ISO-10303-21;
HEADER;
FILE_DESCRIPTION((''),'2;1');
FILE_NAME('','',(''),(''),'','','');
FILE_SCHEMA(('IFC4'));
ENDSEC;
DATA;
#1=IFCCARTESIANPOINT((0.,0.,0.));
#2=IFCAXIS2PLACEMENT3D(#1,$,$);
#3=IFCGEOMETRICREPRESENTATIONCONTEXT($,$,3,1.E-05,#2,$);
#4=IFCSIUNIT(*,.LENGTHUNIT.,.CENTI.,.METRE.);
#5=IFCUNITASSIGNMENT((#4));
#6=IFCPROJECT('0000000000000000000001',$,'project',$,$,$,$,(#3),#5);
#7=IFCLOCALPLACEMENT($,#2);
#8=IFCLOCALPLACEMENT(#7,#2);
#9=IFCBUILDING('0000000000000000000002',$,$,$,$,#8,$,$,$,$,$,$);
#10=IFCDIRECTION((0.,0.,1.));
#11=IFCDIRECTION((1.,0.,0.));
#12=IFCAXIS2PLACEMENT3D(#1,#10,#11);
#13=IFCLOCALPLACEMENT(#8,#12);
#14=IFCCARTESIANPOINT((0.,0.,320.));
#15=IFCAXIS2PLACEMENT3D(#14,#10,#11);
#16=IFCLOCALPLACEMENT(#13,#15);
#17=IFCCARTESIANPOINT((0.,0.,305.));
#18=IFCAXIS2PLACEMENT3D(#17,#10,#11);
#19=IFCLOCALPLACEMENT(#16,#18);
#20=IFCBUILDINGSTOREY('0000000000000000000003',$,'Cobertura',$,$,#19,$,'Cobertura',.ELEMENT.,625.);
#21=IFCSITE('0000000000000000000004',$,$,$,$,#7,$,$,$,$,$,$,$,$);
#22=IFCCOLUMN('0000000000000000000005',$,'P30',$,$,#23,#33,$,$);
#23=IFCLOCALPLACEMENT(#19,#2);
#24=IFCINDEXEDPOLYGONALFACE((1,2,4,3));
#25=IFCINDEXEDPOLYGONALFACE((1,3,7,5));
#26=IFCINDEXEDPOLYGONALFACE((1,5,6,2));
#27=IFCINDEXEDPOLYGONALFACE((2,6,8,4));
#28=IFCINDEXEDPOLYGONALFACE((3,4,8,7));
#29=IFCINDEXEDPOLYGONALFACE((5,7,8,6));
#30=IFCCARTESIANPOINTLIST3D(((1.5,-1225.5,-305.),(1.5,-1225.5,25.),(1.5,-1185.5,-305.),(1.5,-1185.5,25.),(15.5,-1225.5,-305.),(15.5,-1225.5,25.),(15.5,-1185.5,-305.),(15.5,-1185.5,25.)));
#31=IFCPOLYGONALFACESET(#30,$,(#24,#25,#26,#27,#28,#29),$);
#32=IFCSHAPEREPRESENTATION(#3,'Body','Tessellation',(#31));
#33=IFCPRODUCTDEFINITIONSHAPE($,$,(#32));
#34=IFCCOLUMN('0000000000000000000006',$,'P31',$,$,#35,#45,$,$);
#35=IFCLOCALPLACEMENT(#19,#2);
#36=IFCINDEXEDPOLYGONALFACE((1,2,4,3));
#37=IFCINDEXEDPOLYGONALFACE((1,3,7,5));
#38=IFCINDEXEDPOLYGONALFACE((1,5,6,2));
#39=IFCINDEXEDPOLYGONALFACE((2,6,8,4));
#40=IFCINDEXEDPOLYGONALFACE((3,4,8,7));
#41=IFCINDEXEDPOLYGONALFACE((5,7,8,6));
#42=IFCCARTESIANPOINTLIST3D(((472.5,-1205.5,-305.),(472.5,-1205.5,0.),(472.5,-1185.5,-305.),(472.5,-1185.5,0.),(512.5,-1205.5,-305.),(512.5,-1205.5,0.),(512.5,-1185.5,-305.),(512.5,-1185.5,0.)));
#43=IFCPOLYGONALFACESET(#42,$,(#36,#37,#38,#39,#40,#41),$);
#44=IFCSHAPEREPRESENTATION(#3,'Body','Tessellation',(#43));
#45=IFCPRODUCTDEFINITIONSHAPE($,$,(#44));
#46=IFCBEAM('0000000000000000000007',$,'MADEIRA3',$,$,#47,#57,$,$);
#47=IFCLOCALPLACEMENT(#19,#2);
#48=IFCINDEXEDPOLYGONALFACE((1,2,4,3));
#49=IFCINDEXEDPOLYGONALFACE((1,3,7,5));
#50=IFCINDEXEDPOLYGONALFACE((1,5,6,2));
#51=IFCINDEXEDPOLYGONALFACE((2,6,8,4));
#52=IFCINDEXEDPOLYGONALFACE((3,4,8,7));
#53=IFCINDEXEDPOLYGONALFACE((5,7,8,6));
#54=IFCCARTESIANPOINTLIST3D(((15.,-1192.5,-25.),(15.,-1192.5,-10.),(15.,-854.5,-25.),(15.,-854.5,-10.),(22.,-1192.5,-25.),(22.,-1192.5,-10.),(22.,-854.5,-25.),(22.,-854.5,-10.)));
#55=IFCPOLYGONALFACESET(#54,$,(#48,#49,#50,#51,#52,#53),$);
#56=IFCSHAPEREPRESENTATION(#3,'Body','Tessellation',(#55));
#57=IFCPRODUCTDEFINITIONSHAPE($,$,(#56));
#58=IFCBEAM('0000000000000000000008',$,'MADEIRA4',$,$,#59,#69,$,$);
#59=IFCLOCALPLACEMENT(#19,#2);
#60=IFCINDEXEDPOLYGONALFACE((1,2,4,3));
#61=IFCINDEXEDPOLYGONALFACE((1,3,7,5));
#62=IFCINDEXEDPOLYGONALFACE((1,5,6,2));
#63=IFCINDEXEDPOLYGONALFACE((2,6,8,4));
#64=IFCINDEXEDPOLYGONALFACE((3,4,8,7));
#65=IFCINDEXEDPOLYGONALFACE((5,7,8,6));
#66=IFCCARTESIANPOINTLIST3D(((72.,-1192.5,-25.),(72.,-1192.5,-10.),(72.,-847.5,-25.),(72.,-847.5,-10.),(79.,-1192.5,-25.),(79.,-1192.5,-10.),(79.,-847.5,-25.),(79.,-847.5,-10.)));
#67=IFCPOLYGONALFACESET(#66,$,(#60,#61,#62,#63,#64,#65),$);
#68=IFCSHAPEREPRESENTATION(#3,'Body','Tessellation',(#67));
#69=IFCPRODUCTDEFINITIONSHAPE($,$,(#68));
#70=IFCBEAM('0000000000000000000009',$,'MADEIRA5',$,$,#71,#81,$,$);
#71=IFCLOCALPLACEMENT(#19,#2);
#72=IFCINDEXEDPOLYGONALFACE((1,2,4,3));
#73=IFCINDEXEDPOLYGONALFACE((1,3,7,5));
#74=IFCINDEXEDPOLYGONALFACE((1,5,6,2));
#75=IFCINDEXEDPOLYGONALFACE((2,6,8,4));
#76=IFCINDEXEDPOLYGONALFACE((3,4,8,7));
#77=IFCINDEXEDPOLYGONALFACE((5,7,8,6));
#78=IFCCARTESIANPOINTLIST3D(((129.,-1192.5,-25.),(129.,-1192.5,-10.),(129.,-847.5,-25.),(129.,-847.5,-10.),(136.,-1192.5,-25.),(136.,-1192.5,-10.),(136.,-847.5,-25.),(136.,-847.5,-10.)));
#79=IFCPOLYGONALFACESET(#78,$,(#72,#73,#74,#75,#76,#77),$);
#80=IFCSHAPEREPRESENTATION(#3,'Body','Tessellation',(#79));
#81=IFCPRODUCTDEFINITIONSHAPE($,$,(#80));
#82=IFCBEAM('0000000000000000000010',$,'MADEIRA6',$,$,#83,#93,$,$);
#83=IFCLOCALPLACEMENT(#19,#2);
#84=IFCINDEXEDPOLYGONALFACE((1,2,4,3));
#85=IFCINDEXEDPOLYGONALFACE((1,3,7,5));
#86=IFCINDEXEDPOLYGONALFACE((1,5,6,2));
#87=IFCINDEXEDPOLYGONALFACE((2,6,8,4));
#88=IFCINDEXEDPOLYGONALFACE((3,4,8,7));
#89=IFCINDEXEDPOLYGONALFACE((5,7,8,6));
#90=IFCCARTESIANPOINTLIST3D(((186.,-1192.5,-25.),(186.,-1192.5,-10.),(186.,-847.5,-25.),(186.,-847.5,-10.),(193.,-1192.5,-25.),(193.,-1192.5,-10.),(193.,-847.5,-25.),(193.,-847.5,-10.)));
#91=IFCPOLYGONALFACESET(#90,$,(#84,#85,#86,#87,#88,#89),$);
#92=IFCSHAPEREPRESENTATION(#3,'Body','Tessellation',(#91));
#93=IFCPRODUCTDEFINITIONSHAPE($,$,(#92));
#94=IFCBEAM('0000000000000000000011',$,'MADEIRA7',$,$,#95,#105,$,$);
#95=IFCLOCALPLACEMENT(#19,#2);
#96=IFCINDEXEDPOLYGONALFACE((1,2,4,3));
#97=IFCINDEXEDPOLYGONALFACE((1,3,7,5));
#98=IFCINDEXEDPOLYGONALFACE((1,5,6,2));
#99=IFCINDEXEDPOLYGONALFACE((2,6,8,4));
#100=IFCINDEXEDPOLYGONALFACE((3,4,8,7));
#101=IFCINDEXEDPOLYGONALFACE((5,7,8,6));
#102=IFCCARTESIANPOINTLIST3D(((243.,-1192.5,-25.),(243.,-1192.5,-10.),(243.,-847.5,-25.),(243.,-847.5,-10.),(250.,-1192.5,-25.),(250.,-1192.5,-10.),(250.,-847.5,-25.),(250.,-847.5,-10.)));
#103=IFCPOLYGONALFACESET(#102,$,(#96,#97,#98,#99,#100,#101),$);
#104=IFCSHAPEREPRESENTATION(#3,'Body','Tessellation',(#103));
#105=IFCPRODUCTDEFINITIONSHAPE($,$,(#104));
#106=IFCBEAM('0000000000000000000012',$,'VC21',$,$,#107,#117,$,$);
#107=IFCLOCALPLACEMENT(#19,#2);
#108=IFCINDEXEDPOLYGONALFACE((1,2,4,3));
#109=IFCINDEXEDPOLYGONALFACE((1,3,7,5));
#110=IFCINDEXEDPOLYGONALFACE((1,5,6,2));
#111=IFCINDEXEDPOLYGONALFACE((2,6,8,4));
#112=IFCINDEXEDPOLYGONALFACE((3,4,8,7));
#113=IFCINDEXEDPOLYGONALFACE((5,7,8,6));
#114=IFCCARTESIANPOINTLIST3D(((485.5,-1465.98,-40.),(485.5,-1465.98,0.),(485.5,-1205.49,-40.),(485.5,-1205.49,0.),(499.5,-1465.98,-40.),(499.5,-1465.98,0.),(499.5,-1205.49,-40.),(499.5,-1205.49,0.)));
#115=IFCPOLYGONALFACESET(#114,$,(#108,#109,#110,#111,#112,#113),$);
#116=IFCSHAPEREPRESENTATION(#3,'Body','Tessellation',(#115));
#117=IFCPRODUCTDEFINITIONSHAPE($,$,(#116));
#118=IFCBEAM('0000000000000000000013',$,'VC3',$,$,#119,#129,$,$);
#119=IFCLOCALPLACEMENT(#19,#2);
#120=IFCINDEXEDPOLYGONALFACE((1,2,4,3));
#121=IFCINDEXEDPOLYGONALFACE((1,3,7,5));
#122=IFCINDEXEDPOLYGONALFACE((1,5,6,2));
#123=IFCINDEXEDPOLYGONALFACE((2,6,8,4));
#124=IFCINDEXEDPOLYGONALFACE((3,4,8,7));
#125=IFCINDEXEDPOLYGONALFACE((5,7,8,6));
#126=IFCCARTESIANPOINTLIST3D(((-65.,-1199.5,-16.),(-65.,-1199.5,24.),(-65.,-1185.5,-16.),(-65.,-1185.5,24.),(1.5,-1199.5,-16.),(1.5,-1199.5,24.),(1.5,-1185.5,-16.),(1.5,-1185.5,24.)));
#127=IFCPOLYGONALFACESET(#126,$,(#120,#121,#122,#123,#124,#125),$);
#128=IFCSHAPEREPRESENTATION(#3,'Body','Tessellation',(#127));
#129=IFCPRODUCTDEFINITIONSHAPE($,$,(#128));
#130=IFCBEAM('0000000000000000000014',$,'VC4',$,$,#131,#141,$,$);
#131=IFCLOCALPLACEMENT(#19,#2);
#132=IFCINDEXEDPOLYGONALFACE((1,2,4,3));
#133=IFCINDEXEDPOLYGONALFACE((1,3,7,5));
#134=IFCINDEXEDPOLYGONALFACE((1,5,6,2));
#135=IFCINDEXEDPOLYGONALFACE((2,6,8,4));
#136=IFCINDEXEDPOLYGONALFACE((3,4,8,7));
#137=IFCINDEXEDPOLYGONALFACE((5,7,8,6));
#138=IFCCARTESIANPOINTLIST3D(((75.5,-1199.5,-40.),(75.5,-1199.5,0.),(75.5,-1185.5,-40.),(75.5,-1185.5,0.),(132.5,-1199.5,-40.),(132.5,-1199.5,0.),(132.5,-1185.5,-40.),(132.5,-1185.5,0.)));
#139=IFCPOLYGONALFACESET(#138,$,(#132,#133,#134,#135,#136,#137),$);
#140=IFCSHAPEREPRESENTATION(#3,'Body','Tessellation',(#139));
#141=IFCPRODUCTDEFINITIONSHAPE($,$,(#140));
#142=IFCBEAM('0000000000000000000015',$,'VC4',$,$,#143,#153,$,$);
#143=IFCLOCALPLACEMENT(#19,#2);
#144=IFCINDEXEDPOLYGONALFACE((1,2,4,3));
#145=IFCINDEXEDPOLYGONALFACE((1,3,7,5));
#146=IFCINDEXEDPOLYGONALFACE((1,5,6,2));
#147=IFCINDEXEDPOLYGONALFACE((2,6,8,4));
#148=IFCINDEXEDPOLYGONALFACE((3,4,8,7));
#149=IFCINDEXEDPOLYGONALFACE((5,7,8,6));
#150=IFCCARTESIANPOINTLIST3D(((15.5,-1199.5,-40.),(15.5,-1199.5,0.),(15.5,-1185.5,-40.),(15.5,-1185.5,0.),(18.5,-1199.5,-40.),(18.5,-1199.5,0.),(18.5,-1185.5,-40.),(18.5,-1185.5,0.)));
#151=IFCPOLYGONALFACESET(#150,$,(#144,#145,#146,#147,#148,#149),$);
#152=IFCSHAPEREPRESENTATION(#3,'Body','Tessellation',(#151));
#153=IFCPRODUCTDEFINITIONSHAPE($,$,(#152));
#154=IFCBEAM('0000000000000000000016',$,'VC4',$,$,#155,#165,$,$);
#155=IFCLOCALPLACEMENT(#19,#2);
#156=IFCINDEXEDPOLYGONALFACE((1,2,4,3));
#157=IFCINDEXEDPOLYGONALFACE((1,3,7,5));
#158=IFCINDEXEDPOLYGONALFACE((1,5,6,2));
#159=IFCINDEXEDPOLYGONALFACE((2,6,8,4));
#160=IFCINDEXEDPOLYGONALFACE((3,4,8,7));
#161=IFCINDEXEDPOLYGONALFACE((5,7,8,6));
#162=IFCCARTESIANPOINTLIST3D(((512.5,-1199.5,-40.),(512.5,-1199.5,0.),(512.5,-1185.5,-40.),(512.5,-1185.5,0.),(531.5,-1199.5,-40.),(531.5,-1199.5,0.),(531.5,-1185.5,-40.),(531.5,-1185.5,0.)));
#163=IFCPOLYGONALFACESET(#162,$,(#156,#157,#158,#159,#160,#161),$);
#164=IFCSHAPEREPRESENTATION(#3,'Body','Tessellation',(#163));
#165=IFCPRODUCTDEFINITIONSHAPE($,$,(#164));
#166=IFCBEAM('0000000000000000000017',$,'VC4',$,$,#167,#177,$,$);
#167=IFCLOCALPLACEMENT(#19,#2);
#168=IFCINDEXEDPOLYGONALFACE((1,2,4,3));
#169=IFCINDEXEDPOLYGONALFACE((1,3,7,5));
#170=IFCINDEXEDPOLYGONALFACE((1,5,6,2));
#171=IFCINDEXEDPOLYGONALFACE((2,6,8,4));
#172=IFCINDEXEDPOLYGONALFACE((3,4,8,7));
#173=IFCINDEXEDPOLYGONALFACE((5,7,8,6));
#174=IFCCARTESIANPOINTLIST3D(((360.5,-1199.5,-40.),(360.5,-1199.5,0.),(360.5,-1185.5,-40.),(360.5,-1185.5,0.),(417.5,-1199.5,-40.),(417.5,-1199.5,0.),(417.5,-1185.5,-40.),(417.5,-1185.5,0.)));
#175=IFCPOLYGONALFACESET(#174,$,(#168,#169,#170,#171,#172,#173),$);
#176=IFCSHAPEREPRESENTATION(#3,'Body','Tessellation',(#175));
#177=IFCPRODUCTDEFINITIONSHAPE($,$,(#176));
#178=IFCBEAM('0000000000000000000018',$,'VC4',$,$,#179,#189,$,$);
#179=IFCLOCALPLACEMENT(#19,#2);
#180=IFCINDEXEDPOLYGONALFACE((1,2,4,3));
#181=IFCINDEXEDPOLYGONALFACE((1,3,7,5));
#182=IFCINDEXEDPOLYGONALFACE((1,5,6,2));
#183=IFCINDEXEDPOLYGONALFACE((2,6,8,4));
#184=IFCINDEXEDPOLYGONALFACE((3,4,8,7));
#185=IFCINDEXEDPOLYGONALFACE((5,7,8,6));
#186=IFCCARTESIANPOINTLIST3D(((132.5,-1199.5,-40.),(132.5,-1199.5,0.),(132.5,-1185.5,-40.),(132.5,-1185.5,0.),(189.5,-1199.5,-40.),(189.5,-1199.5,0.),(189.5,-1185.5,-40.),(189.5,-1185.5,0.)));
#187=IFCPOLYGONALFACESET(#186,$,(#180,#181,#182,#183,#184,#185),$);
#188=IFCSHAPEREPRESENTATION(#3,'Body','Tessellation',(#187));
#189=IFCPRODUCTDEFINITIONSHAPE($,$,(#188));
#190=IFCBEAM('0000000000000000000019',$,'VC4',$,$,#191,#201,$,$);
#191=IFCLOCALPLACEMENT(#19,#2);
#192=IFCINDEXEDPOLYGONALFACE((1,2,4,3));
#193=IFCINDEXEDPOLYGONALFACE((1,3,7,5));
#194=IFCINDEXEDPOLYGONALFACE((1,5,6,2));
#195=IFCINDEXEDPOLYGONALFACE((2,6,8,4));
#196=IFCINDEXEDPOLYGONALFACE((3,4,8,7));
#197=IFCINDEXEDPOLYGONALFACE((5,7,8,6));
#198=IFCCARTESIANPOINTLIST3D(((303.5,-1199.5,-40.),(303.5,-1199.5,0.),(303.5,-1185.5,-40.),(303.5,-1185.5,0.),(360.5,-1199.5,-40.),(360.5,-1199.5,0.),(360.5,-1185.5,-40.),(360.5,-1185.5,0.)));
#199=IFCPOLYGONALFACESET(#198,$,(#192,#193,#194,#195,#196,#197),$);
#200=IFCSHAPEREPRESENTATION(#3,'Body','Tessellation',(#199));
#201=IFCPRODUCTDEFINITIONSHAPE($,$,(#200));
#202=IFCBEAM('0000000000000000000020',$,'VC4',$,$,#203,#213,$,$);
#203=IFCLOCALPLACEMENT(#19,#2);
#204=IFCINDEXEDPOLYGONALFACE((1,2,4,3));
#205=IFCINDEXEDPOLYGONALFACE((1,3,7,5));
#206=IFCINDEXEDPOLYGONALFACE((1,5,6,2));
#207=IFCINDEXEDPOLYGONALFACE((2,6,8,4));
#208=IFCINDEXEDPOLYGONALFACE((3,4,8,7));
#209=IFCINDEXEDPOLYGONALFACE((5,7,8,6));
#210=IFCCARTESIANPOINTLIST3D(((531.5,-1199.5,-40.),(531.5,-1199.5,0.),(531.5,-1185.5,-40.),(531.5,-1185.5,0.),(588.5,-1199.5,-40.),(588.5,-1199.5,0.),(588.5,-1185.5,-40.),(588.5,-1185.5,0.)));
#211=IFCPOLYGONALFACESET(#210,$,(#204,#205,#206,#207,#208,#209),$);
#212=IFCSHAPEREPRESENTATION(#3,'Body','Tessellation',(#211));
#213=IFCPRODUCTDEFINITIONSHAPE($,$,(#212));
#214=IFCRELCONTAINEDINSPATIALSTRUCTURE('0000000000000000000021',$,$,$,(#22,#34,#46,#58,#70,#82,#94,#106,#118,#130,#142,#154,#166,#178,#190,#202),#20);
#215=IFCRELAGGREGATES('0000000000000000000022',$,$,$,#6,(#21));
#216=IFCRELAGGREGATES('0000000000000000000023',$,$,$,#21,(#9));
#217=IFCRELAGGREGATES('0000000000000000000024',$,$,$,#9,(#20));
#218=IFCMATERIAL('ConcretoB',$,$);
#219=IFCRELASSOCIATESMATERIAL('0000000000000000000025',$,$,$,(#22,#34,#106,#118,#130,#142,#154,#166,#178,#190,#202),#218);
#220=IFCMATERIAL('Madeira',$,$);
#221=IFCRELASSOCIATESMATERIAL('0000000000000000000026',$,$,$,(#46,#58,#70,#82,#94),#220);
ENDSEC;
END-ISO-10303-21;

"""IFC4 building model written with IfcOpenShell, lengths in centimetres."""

from ifc_helpers import new_model, si_unit, frame, origin, origin_with_axes, place, context, project, spatial, polyline, outline, extrude, material, element, save


model = new_model("IFC4")

# Units and contexts
context_of_model = context(None, 3, precision=1e-05, world=origin())
ifc_project = project(units=[si_unit("LENGTHUNIT", "METRE", prefix="CENTI")], contexts=[context_of_model])

# Site, building, storey
site_placement = place(None, origin())
site = spatial("IfcSite", under=ifc_project, at=site_placement)
building_placement = place(site_placement, origin())
building = spatial("IfcBuilding", under=site, at=building_placement)
placement_1 = place(building_placement, origin_with_axes())
placement_2 = place(placement_1, frame((0.0, 0.0, 320.0), z_axis=(0.0, 0.0, 1.0), x_axis=(1.0, 0.0, 0.0)))
storey_placement = place(placement_2, frame((0.0, 0.0, 305.0), z_axis=(0.0, 0.0, 1.0), x_axis=(1.0, 0.0, 0.0)))
storey = spatial("IfcBuildingStorey", under=building, at=storey_placement, Name="Cobertura", LongName="Cobertura", CompositionType="ELEMENT", Elevation=625.0)

# Columns
ifc_material_1 = material(Name="ConcretoB")
column_1_placement = place(storey_placement, frame((8.5, -1205.5, 25.0), z_axis=(0.0, 0.0, 1.0), x_axis=(1.0, 0.0, 0.0)))
element("IfcColumn", 1, at=column_1_placement, inside=storey, material=ifc_material_1, Name="P30", context=context_of_model, shape_type="SolidModel", body=[
    extrude(outline(polyline([(7.0, 20.0), (-7.0, 20.0), (-7.0, -20.0), (7.0, -20.0), (7.0, 20.0)])), frame((0.0, 0.0, 0.0), z_axis=(0.0, 0.0, 1.0), x_axis=(1.0, 0.0, 0.0)), (0.0, 0.0, -1.0), 330.0),
])
column_2_placement = place(storey_placement, frame((492.5, -1195.5, 0.0), z_axis=(0.0, 0.0, 1.0), x_axis=(1.0, 0.0, 0.0)))
element("IfcColumn", 2, at=column_2_placement, inside=storey, material=ifc_material_1, Name="P31", context=context_of_model, shape_type="SolidModel", body=[
    extrude(outline(polyline([(-20.0, 10.0), (-20.0, -10.0), (20.0, -10.0), (20.0, 10.0), (-20.0, 10.0)])), origin_with_axes(), (0.0, 0.0, -1.0), 305.0),
])

# Beams
ifc_material_2 = material(Name="Madeira")
beam_1_placement = place(storey_placement, frame((18.5, -1023.5, -10.0), z_axis=(0.0, 0.0, 1.0), x_axis=(1.0, 0.0, 0.0)))
element("IfcBeam", 3, at=beam_1_placement, inside=storey, material=ifc_material_2, Name="MADEIRA3", context=context_of_model, shape_type="SolidModel", body=[
    extrude(outline(polyline([(-3.5, -7.5), (-3.5, 7.5), (3.5, 7.5), (3.5, -7.5), (-3.5, -7.5)])), frame((0.0, -169.0, -7.5), z_axis=(0.0, 1.0, 0.0), x_axis=(1.0, 0.0, 0.0)), (0.0, 0.0, 1.0), 338.0),
])
for number, where, z_axis, x_axis, name in (
    (4, (75.5, -1020.0, -10.0), (0.0, 0.0, 1.0), (1.0, 0.0, 0.0), "MADEIRA4"),
    (5, (132.5, -1020.0, -10.0), (0.0, 0.0, 1.0), (1.0, 0.0, 0.0), "MADEIRA5"),
    (6, (189.5, -1020.0, -10.0), (0.0, 0.0, 1.0), (1.0, 0.0, 0.0), "MADEIRA6"),
    (7, (246.5, -1020.0, -10.0), (0.0, 0.0, 1.0), (1.0, 0.0, 0.0), "MADEIRA7"),
):
    element("IfcBeam", number, at=place(storey_placement, frame(where, z_axis=z_axis, x_axis=x_axis)), inside=storey, material=ifc_material_2, Name=name, context=context_of_model, shape_type="SolidModel", body=[
        extrude(outline(polyline([(-3.5, -7.5), (-3.5, 7.5), (3.5, 7.5), (3.5, -7.5), (-3.5, -7.5)])), frame((0.0, -172.5, -7.5), z_axis=(0.0, 1.0, 0.0), x_axis=(1.0, 0.0, 0.0)), (0.0, 0.0, 1.0), 345.0),
    ])
beam_2_placement = place(storey_placement, frame((492.5, -1335.74, 0.0), z_axis=(0.0, 0.0, 1.0), x_axis=(1.0, 0.0, 0.0)))
element("IfcBeam", 8, at=beam_2_placement, inside=storey, material=ifc_material_1, Name="VC21", context=context_of_model, shape_type="SolidModel", body=[
    extrude(outline(polyline([(-7.0, -20.0), (7.0, -20.0), (7.0, 20.0), (-7.0, 20.0), (-7.0, -20.0)])), frame((0.0, -130.25, -20.0), z_axis=(0.0, 1.0, 0.0), x_axis=(1.0, 0.0, 0.0)), (0.0, 0.0, 1.0), 260.49),
])
beam_3_placement = place(storey_placement, frame((-31.75, -1192.5, 24.0), z_axis=(0.0, 0.0, 1.0), x_axis=(1.0, 0.0, 0.0)))
element("IfcBeam", 9, at=beam_3_placement, inside=storey, material=ifc_material_1, Name="VC3", context=context_of_model, shape_type="SolidModel", body=[
    extrude(outline(polyline([(-7.0, -20.0), (7.0, -20.0), (7.0, 20.0), (-7.0, 20.0), (-7.0, -20.0)])), frame((-33.25, 0.0, -20.0), z_axis=(1.0, 0.0, 0.0), x_axis=(0.0, -1.0, 0.0)), (0.0, 0.0, 1.0), 66.5),
])
beam_4_placement = place(storey_placement, frame((104.0, -1192.5, 0.0), z_axis=(0.0, 0.0, 1.0), x_axis=(1.0, 0.0, 0.0)))
element("IfcBeam", 10, at=beam_4_placement, inside=storey, material=ifc_material_1, Name="VC4", context=context_of_model, shape_type="SolidModel", body=[
    extrude(outline(polyline([(-7.0, -20.0), (7.0, -20.0), (7.0, 20.0), (-7.0, 20.0), (-7.0, -20.0)])), frame((-28.5, 0.0, -20.0), z_axis=(1.0, 0.0, 0.0), x_axis=(0.0, -1.0, 0.0)), (0.0, 0.0, 1.0), 57.0),
])
beam_5_placement = place(storey_placement, frame((17.0, -1192.5, 0.0), z_axis=(0.0, 0.0, 1.0), x_axis=(1.0, 0.0, 0.0)))
element("IfcBeam", 11, at=beam_5_placement, inside=storey, material=ifc_material_1, Name="VC4", context=context_of_model, shape_type="SolidModel", body=[
    extrude(outline(polyline([(-7.0, -20.0), (7.0, -20.0), (7.0, 20.0), (-7.0, 20.0), (-7.0, -20.0)])), frame((-1.5, 0.0, -20.0), z_axis=(1.0, 0.0, 0.0), x_axis=(0.0, -1.0, 0.0)), (0.0, 0.0, 1.0), 3.0),
])
beam_6_placement = place(storey_placement, frame((522.0, -1192.5, 0.0), z_axis=(0.0, 0.0, 1.0), x_axis=(1.0, 0.0, 0.0)))
element("IfcBeam", 12, at=beam_6_placement, inside=storey, material=ifc_material_1, Name="VC4", context=context_of_model, shape_type="SolidModel", body=[
    extrude(outline(polyline([(-7.0, -20.0), (7.0, -20.0), (7.0, 20.0), (-7.0, 20.0), (-7.0, -20.0)])), frame((-9.5, 0.0, -20.0), z_axis=(1.0, 0.0, 0.0), x_axis=(0.0, -1.0, 0.0)), (0.0, 0.0, 1.0), 19.0),
])
for number, where, z_axis, x_axis, name in (
    (13, (389.0, -1192.5, 0.0), (0.0, 0.0, 1.0), (1.0, 0.0, 0.0), "VC4"),
    (14, (161.0, -1192.5, 0.0), (0.0, 0.0, 1.0), (1.0, 0.0, 0.0), "VC4"),
    (15, (332.0, -1192.5, 0.0), (0.0, 0.0, 1.0), (1.0, 0.0, 0.0), "VC4"),
    (16, (560.0, -1192.5, 0.0), (0.0, 0.0, 1.0), (1.0, 0.0, 0.0), "VC4"),
):
    element("IfcBeam", number, at=place(storey_placement, frame(where, z_axis=z_axis, x_axis=x_axis)), inside=storey, material=ifc_material_1, Name=name, context=context_of_model, shape_type="SolidModel", body=[
        extrude(outline(polyline([(-7.0, -20.0), (7.0, -20.0), (7.0, 20.0), (-7.0, 20.0), (-7.0, -20.0)])), frame((-28.5, 0.0, -20.0), z_axis=(1.0, 0.0, 0.0), x_axis=(0.0, -1.0, 0.0)), (0.0, 0.0, 1.0), 57.0),
    ])

save(model, "model.ifc")
